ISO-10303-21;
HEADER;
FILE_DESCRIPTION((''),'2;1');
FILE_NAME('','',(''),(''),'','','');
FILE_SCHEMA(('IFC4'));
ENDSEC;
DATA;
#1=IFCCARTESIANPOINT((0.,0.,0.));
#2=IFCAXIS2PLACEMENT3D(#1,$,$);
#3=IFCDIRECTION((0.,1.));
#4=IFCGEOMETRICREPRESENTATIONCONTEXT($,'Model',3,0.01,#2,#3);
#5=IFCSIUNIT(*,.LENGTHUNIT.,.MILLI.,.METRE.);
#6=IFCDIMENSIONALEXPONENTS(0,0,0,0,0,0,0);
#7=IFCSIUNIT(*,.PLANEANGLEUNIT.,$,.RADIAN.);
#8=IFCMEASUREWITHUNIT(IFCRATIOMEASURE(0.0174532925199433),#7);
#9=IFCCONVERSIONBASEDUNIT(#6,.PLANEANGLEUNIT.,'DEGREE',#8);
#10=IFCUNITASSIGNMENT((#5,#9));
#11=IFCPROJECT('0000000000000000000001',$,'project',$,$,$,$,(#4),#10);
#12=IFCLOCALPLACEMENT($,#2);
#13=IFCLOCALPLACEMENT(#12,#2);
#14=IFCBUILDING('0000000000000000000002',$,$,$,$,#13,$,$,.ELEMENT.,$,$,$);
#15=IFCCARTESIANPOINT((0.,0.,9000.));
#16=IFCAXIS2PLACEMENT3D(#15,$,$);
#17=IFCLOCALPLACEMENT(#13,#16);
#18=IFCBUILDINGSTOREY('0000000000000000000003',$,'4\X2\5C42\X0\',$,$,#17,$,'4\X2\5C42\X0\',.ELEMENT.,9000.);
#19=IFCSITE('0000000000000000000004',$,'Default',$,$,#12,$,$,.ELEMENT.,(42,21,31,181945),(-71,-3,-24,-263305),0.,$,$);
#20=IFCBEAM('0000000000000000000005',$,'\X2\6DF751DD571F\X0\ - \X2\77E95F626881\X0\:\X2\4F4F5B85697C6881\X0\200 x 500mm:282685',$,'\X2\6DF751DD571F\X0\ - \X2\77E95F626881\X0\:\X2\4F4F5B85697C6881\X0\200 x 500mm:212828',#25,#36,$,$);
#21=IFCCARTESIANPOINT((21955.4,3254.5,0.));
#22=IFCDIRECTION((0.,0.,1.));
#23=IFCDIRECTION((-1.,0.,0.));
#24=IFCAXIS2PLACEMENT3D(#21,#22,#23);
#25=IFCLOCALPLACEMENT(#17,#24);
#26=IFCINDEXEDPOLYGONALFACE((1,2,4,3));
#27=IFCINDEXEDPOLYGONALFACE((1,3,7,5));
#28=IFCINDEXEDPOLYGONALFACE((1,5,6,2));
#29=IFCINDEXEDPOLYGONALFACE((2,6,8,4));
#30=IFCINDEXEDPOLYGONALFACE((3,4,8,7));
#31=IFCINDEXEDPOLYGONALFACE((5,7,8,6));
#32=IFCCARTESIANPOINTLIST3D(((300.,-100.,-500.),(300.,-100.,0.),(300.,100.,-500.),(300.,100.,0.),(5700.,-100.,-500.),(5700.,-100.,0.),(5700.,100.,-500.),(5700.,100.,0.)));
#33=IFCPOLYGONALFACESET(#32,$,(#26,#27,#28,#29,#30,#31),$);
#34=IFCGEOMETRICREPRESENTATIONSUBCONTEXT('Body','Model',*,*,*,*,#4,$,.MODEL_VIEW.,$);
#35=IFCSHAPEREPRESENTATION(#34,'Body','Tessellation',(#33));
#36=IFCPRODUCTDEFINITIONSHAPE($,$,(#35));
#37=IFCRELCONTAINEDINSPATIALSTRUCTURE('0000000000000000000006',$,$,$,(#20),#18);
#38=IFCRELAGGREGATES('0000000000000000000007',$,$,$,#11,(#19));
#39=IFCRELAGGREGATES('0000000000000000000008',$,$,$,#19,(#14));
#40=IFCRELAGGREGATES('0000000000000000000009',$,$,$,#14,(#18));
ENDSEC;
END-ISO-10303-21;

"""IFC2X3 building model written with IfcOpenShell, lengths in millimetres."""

from ifc_helpers import new_model, entity, si_unit, converted_unit, direction, frame, frame_2d, origin, place, context, subcontext, project, spatial, rectangle, extrude, element, save


model = new_model("IFC2X3")

# Units and contexts
model_context = context("Model", 3, precision=0.01, world=origin(), true_north=direction((0.0, 1.0)))
body_context = subcontext(model_context, "Body", "Model", "MODEL_VIEW")
ifc_project = project(units=[si_unit("LENGTHUNIT", "METRE", prefix="MILLI"), converted_unit("PLANEANGLEUNIT", "DEGREE", entity("IfcRatioMeasure", 0.0174532925199433), si_unit("PLANEANGLEUNIT", "RADIAN"), dimensions=[0, 0, 0, 0, 0, 0, 0])], contexts=[model_context])

# Site, building, storey
site_placement = place(None, origin())
site = spatial("IfcSite", under=ifc_project, at=site_placement, Name="Default", CompositionType="ELEMENT", RefLatitude=(42, 21, 31, 181945), RefLongitude=(-71, -3, -24, -263305), RefElevation=0.0)
building_placement = place(site_placement, origin())
building = spatial("IfcBuilding", under=site, at=building_placement, CompositionType="ELEMENT")
storey_placement = place(building_placement, frame((0.0, 0.0, 9000.0)))
storey = spatial("IfcBuildingStorey", under=building, at=storey_placement, Name="4层", LongName="4层", CompositionType="ELEMENT", Elevation=9000.0)

# Beam
beam_placement = place(storey_placement, frame((21955.4, 3254.5, 0.0), z_axis=(0.0, 0.0, 1.0), x_axis=(-1.0, 0.0, 0.0)))
element("IfcBeam", 1, at=beam_placement, inside=storey, Name="混凝土 - 矩形梁:住宅楼梁200 x 500mm:282685", ObjectType="混凝土 - 矩形梁:住宅楼梁200 x 500mm:212828", context=body_context, shape_type="SweptSolid", body=[
    extrude(rectangle(XDim=500.0, YDim=200.0, at=frame_2d((0.0, 0.0), x_axis=(1.0, 0.0))), frame((300.0, 0.0, -250.0), z_axis=(1.0, 0.0, 0.0), x_axis=(0.0, 0.0, -1.0)), (0.0, 0.0, 1.0), 5400.0),
])

save(model, "model.ifc")
